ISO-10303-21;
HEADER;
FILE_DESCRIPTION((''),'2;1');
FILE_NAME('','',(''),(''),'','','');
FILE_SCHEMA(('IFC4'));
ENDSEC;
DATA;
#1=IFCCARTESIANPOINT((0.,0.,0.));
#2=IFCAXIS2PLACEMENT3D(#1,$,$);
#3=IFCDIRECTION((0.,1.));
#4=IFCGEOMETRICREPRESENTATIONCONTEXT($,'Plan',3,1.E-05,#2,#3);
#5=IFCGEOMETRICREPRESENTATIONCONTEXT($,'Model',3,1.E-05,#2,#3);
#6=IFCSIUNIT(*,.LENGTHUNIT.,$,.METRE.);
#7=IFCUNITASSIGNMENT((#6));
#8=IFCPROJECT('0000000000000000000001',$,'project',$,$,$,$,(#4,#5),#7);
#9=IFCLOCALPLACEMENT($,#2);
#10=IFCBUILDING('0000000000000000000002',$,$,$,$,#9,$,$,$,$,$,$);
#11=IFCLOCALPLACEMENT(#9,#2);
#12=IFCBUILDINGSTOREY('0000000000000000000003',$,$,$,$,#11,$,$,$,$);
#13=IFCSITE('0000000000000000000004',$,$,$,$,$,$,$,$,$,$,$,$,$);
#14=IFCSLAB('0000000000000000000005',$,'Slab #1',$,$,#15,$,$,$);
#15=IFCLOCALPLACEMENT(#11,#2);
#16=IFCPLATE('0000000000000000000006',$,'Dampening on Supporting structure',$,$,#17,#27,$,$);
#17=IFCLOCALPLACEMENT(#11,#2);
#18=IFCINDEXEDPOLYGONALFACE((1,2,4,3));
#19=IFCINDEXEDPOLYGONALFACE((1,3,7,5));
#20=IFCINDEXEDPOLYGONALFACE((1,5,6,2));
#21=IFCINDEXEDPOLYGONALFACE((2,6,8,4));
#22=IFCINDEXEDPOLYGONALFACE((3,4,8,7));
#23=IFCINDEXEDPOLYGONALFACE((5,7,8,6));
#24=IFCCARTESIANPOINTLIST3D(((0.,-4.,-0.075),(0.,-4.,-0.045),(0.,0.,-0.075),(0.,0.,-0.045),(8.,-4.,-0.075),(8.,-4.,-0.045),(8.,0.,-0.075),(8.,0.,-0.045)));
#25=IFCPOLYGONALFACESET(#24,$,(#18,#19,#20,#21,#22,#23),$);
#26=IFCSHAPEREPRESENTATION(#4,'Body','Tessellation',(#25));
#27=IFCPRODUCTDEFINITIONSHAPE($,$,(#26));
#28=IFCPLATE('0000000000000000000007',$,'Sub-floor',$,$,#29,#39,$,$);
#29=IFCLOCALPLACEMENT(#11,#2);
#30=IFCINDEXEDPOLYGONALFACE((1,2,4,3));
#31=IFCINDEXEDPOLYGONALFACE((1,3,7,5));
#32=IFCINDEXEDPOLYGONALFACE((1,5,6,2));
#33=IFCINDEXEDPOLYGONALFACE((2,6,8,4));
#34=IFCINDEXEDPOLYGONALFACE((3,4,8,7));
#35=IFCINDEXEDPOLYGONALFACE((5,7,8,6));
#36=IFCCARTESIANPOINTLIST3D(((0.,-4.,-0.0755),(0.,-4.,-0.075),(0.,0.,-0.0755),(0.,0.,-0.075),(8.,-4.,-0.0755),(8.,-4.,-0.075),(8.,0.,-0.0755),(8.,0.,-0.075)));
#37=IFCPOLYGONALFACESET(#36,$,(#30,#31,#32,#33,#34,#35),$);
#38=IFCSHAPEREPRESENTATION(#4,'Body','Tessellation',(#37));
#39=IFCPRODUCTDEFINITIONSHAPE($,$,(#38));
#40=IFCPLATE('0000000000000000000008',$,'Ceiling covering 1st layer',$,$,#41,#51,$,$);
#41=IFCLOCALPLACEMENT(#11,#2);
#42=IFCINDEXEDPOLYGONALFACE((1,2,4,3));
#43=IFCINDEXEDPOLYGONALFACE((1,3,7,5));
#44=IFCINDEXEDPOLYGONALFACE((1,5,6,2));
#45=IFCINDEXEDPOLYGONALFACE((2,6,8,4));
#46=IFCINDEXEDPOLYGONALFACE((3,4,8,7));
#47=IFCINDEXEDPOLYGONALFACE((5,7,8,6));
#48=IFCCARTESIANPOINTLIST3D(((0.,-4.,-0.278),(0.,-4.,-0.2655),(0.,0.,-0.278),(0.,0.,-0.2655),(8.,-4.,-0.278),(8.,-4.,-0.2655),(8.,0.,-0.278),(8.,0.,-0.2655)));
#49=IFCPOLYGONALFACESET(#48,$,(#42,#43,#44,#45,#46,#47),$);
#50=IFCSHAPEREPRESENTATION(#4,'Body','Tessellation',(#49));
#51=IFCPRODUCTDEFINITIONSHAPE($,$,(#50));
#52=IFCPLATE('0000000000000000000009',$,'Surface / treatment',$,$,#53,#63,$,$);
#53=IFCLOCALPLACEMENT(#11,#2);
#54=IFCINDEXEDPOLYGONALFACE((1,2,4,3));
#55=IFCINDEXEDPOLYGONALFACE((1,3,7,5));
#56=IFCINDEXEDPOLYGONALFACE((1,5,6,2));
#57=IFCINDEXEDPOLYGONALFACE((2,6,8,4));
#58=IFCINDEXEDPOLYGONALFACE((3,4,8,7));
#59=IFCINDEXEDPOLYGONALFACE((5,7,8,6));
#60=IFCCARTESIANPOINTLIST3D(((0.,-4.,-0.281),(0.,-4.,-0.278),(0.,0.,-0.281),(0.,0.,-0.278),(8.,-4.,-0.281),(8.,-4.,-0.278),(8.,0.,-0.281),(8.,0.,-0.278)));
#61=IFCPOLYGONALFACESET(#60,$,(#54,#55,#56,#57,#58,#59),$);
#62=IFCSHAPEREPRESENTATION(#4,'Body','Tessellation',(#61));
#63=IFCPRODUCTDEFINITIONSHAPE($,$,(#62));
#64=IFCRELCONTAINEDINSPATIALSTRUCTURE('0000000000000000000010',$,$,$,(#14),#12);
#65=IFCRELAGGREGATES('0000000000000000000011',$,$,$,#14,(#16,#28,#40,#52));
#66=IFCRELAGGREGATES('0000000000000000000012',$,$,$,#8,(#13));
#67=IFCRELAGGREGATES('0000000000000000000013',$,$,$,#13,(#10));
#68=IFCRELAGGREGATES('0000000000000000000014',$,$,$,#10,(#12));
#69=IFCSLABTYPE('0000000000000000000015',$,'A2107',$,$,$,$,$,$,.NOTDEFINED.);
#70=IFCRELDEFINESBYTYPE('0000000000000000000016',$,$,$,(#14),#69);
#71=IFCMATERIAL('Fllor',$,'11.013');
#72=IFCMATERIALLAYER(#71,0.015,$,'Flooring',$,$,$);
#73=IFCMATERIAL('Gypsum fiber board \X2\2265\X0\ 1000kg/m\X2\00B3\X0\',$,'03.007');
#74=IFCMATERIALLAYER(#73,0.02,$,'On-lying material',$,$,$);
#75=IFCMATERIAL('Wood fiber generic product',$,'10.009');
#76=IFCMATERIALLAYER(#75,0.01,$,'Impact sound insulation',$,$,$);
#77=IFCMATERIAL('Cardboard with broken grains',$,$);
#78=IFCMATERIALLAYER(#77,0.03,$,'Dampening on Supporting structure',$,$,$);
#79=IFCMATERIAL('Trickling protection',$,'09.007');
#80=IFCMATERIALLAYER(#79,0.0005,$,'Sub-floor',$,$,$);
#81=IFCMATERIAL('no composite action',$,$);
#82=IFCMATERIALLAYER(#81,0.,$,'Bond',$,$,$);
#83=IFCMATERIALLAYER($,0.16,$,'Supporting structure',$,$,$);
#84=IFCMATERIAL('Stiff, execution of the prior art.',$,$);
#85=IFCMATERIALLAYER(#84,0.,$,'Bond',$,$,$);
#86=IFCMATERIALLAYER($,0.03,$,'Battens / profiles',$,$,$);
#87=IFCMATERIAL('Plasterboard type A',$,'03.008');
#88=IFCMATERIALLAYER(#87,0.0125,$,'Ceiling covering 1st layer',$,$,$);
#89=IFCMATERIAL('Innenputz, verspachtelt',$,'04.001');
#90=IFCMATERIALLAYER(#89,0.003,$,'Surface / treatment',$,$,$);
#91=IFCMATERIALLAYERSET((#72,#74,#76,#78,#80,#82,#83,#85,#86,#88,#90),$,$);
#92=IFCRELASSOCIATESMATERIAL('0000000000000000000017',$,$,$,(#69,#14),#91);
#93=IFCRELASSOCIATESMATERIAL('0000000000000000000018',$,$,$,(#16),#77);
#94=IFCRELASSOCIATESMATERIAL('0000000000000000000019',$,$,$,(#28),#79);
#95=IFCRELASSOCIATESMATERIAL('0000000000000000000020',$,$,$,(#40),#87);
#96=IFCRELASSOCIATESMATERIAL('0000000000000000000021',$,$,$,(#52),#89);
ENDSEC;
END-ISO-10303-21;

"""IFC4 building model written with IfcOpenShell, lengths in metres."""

from ifc_helpers import new_model, si_unit, direction, frame, frame_2d, origin, place, context, project, spatial, rectangle, extrude, material, layer, layer_set, type_object, element, aggregate, save


model = new_model("IFC4")

# Units and contexts
plan_context = context("Plan", 3, precision=1e-05, world=origin(), true_north=direction((0.0, 1.0)))
model_context = context("Model", 3, precision=1e-05, world=origin(), true_north=direction((0.0, 1.0)))
ifc_project = project(units=[si_unit("LENGTHUNIT", "METRE")], contexts=[plan_context, model_context])

# Site, building, storey
site = spatial("IfcSite", under=ifc_project)
building_placement = place(None, origin())
building = spatial("IfcBuilding", under=site, at=building_placement)
storey_placement = place(building_placement, origin())
storey = spatial("IfcBuildingStorey", under=building, at=storey_placement)

# Slab, plates
ifc_material_1 = material(Name="Fllor", Category="11.013")
ifc_layer_1 = layer(ifc_material_1, 0.015, Name="Flooring")
ifc_material_2 = material(Name="Gypsum fiber board ≥ 1000kg/m³", Category="03.007")
ifc_layer_2 = layer(ifc_material_2, 0.02, Name="On-lying material")
ifc_material_3 = material(Name="Wood fiber generic product", Category="10.009")
ifc_layer_3 = layer(ifc_material_3, 0.01, Name="Impact sound insulation")
ifc_material_4 = material(Name="Cardboard with broken grains")
ifc_layer_4 = layer(ifc_material_4, 0.03, Name="Dampening on Supporting structure")
ifc_material_5 = material(Name="Trickling protection", Category="09.007")
ifc_layer_5 = layer(ifc_material_5, 0.0005, Name="Sub-floor")
ifc_material_6 = material(Name="no composite action")
ifc_layer_6 = layer(ifc_material_6, 0.0, Name="Bond")
ifc_layer_7 = layer(None, 0.16, Name="Supporting structure")
ifc_material_7 = material(Name="Stiff, execution of the prior art.")
ifc_layer_8 = layer(ifc_material_7, 0.0, Name="Bond")
ifc_layer_9 = layer(None, 0.03, Name="Battens / profiles")
ifc_material_8 = material(Name="Plasterboard type A", Category="03.008")
ifc_layer_10 = layer(ifc_material_8, 0.0125, Name="Ceiling covering 1st layer")
ifc_material_9 = material(Name="Innenputz, verspachtelt", Category="04.001")
ifc_layer_11 = layer(ifc_material_9, 0.003, Name="Surface / treatment")
ifc_layer_set = layer_set([ifc_layer_1, ifc_layer_2, ifc_layer_3, ifc_layer_4, ifc_layer_5, ifc_layer_6, ifc_layer_7, ifc_layer_8, ifc_layer_9, ifc_layer_10, ifc_layer_11])
slab_type = type_object("IfcSlabType", Name="A2107", PredefinedType="NOTDEFINED", material=ifc_layer_set)
slab_placement = place(None, frame((0.0, 0.0, 0.0), z_axis=(0.0, 0.0, -1.0), x_axis=(1.0, 0.0, 0.0)))
slab = element("IfcSlab", 1, at=slab_placement, inside=storey, type_object=slab_type, material=ifc_layer_set, Name="Slab #1")
plate_1_placement = place(slab_placement, origin())
plate_1 = element("IfcPlate", 2, at=plate_1_placement, material=ifc_material_4, Name="Dampening on Supporting structure", context=plan_context, shape_type="SweptSolid", body=[
    extrude(rectangle(XDim=8.0, YDim=4.0, at=frame_2d((4.0, 2.0), x_axis=(1.0, 0.0))), frame((0.0, 0.0, 0.045), z_axis=(0.0, 0.0, 1.0), x_axis=(1.0, 0.0, 0.0)), (0.0, 0.0, 1.0), 0.03),
])
plate_2_placement = place(slab_placement, origin())
plate_2 = element("IfcPlate", 3, at=plate_2_placement, material=ifc_material_5, Name="Sub-floor", context=plan_context, shape_type="SweptSolid", body=[
    extrude(rectangle(XDim=8.0, YDim=4.0, at=frame_2d((4.0, 2.0), x_axis=(1.0, 0.0))), frame((0.0, 0.0, 0.075), z_axis=(0.0, 0.0, 1.0), x_axis=(1.0, 0.0, 0.0)), (0.0, 0.0, 1.0), 0.0005),
])
plate_3_placement = place(slab_placement, origin())
plate_3 = element("IfcPlate", 4, at=plate_3_placement, material=ifc_material_8, Name="Ceiling covering 1st layer", context=plan_context, shape_type="SweptSolid", body=[
    extrude(rectangle(XDim=8.0, YDim=4.0, at=frame_2d((4.0, 2.0), x_axis=(1.0, 0.0))), frame((0.0, 0.0, 0.2655), z_axis=(0.0, 0.0, 1.0), x_axis=(1.0, 0.0, 0.0)), (0.0, 0.0, 1.0), 0.0125),
])
plate_4_placement = place(slab_placement, origin())
plate_4 = element("IfcPlate", 5, at=plate_4_placement, material=ifc_material_9, Name="Surface / treatment", context=plan_context, shape_type="SweptSolid", body=[
    extrude(rectangle(XDim=8.0, YDim=4.0, at=frame_2d((4.0, 2.0), x_axis=(1.0, 0.0))), frame((0.0, 0.0, 0.278), z_axis=(0.0, 0.0, 1.0), x_axis=(1.0, 0.0, 0.0)), (0.0, 0.0, 1.0), 0.003),
])
aggregate(slab, [plate_1, plate_2, plate_3, plate_4])

save(model, "model.ifc")
